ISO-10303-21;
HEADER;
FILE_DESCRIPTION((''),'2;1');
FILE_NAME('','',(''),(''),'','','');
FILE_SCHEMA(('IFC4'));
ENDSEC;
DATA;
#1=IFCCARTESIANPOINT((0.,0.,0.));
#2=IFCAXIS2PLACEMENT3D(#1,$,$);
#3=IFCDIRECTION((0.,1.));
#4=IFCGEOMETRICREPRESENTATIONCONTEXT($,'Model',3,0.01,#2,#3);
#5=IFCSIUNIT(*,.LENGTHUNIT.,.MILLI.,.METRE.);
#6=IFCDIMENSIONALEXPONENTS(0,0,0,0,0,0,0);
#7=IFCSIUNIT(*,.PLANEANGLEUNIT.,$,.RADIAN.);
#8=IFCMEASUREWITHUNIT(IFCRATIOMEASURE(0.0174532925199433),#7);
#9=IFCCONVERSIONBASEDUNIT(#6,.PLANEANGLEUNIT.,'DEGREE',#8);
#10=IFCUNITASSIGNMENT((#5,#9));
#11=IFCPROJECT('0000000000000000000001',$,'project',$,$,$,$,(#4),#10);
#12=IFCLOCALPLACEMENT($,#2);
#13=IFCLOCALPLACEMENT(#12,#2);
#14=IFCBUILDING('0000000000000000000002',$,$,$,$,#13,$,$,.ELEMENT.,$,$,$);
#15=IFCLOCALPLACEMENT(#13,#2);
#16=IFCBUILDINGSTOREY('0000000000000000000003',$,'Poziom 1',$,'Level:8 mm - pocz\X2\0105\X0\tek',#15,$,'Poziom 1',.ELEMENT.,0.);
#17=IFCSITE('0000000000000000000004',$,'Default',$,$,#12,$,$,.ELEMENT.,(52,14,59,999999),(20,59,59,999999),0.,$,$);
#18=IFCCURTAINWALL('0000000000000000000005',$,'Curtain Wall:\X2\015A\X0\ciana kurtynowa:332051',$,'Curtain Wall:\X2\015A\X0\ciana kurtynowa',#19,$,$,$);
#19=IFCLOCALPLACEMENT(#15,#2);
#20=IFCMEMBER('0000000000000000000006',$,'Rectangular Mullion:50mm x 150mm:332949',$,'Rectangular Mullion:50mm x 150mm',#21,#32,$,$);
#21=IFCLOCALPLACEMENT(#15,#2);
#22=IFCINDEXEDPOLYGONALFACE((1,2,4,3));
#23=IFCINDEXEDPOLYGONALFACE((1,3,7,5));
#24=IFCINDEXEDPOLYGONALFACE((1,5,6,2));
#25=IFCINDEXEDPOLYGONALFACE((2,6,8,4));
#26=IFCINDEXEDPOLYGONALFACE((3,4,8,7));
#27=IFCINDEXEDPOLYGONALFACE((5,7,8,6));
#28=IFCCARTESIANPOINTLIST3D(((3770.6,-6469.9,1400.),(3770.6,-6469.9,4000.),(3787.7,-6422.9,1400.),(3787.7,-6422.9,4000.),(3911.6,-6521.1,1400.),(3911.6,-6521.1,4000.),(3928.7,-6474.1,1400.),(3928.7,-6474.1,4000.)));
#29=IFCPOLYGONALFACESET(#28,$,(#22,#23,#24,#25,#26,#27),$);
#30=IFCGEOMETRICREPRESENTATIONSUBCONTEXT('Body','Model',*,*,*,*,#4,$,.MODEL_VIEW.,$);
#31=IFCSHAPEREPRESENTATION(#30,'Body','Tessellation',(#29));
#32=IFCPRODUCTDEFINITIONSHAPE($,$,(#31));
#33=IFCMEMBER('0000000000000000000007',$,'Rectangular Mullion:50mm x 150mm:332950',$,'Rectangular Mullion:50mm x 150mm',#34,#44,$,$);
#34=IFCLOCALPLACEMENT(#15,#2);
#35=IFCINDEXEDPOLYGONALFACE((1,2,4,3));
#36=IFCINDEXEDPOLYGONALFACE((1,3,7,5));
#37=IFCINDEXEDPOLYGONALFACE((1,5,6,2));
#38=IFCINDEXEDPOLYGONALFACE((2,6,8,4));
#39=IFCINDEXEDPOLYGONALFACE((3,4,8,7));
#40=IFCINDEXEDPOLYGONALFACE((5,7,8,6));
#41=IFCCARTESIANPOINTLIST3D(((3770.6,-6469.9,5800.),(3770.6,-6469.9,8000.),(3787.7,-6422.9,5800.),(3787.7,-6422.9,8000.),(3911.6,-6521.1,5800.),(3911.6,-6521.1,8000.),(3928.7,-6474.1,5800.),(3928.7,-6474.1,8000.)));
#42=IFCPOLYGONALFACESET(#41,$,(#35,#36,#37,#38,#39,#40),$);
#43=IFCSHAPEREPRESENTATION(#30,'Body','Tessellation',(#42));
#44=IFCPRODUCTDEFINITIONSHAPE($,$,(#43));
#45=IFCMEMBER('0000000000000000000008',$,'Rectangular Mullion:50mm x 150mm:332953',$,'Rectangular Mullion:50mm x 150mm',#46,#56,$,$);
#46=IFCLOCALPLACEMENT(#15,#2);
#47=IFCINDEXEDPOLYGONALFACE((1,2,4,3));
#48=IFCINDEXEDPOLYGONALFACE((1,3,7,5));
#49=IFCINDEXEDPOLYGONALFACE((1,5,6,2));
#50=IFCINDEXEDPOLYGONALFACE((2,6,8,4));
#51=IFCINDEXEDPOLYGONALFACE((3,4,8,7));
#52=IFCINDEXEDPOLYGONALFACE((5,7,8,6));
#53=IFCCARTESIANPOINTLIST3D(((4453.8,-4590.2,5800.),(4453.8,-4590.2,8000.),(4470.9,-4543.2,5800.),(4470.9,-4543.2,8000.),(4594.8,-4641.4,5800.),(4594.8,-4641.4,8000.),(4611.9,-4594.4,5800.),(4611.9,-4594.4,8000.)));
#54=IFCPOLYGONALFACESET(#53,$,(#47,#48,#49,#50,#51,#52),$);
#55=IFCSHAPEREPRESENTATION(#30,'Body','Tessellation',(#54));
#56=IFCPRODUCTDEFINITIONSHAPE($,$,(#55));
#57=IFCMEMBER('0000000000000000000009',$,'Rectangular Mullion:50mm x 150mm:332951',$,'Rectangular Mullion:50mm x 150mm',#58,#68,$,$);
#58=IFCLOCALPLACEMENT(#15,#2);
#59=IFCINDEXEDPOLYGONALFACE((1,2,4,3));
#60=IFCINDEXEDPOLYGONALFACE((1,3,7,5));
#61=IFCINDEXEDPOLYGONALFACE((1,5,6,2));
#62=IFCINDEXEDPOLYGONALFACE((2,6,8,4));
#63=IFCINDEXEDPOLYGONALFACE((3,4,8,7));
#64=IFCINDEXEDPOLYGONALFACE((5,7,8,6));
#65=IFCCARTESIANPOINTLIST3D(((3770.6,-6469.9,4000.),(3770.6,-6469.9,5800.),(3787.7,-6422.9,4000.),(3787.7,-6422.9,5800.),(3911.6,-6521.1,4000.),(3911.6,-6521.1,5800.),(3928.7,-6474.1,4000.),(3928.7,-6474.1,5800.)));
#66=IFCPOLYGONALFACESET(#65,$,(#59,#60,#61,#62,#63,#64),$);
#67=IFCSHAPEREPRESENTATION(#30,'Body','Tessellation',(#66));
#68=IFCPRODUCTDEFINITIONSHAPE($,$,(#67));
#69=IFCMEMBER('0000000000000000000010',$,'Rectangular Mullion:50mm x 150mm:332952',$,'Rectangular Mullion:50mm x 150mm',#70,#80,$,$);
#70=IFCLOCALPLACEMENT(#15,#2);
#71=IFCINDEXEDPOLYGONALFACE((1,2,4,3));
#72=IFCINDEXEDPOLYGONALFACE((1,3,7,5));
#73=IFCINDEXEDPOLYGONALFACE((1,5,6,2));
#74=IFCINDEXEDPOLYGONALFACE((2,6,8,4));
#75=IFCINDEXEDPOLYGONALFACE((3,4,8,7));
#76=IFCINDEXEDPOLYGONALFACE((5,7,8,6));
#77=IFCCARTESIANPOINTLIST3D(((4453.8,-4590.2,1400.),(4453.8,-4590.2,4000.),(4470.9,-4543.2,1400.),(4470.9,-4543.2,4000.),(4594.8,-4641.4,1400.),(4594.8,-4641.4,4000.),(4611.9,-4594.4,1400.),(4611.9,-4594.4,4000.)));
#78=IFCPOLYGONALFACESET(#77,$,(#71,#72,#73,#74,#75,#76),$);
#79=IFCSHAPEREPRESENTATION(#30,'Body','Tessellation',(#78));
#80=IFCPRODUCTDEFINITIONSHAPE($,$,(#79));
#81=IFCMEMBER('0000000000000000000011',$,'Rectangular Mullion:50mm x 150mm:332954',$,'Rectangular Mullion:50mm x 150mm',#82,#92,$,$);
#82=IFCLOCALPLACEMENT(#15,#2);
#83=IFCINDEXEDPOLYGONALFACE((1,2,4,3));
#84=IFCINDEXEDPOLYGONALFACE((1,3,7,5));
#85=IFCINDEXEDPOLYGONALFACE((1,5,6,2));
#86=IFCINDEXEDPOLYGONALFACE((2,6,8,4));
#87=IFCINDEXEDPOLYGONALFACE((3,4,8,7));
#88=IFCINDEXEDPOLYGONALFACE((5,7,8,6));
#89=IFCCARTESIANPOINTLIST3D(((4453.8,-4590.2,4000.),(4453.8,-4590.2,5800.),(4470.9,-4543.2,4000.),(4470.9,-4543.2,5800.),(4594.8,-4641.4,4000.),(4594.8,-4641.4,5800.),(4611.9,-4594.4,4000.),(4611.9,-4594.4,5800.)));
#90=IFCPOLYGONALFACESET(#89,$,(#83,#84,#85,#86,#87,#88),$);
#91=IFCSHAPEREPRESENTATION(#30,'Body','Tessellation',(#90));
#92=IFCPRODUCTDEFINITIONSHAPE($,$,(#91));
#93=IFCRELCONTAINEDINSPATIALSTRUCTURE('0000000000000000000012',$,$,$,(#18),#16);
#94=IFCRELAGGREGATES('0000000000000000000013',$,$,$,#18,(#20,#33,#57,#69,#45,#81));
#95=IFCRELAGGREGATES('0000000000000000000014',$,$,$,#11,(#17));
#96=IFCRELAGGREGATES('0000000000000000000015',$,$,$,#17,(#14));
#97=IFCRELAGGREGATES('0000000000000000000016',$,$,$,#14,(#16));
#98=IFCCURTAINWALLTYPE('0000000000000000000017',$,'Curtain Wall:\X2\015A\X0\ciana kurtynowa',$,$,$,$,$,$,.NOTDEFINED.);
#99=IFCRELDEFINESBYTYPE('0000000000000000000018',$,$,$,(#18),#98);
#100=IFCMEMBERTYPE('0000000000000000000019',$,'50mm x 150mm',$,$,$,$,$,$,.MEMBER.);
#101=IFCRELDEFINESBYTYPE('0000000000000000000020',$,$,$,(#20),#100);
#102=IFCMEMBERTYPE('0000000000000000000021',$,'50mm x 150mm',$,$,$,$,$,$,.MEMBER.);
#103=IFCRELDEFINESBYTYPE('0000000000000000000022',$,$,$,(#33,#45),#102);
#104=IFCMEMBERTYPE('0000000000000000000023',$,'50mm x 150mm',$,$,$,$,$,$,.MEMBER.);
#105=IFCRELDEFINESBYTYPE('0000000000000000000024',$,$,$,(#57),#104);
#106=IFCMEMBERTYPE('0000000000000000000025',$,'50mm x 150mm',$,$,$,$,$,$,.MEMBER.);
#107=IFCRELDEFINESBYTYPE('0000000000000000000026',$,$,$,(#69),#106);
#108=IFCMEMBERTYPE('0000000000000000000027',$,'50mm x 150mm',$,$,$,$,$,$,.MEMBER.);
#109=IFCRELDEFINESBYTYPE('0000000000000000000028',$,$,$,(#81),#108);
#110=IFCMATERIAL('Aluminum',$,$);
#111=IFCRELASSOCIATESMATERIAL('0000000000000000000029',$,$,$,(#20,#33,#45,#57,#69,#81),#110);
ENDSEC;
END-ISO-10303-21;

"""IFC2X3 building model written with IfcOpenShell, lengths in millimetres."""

from ifc_helpers import new_model, entity, si_unit, converted_unit, direction, frame, origin, origin_2d_with_axis, place, context, subcontext, project, spatial, rectangle, extrude, source, transform, mapped, material, type_object, type_shapes, element, aggregate, save


model = new_model("IFC2X3")

# Units and contexts
model_context = context("Model", 3, precision=0.01, world=origin(), true_north=direction((0.0, 1.0)))
body_context = subcontext(model_context, "Body", "Model", "MODEL_VIEW")
ifc_project = project(units=[si_unit("LENGTHUNIT", "METRE", prefix="MILLI"), converted_unit("PLANEANGLEUNIT", "DEGREE", entity("IfcRatioMeasure", 0.0174532925199433), si_unit("PLANEANGLEUNIT", "RADIAN"), dimensions=[0, 0, 0, 0, 0, 0, 0])], contexts=[model_context])

# Site, building, storey
site_placement = place(None, origin())
site = spatial("IfcSite", under=ifc_project, at=site_placement, Name="Default", CompositionType="ELEMENT", RefLatitude=(52, 14, 59, 999999), RefLongitude=(20, 59, 59, 999999), RefElevation=0.0)
building_placement = place(site_placement, origin())
building = spatial("IfcBuilding", under=site, at=building_placement, CompositionType="ELEMENT")
storey_placement = place(building_placement, origin())
storey = spatial("IfcBuildingStorey", under=building, at=storey_placement, Name="Poziom 1", ObjectType="Level:8 mm - początek", LongName="Poziom 1", CompositionType="ELEMENT", Elevation=0.0)

# Curtain wall, members
curtain_wall_type = type_object("IfcCurtainWallType", Name="Curtain Wall:Ściana kurtynowa", PredefinedType="NOTDEFINED")
curtain_wall_placement = place(storey_placement, origin())
curtain_wall = element("IfcCurtainWall", 1, at=curtain_wall_placement, inside=storey, type_object=curtain_wall_type, Name="Curtain Wall:Ściana kurtynowa:332051", ObjectType="Curtain Wall:Ściana kurtynowa")
ifc_material_1 = material(Name="Aluminum")
member_type_1 = type_object("IfcMemberType", Name="50mm x 150mm", PredefinedType="MEMBER")
shared_shape_1 = source(origin(), body_context, "Body", "SweptSolid", [
    extrude(rectangle(XDim=150.0, YDim=50.0, at=origin_2d_with_axis()), frame((0.0, 0.0, -2600.0), z_axis=(0.0, 0.0, 1.0), x_axis=(0.0, -1.0, 0.0)), (0.0, 0.0, 1.0), 2600.0),
])
type_shapes(member_type_1, [shared_shape_1])
member_1_placement = place(storey_placement, frame((3849.7, -6472.0, 1400.0), z_axis=(0.0, 0.0, -1.0), x_axis=(0.341586, 0.939851, 0.0)))
member_1 = element("IfcMember", 2, at=member_1_placement, type_object=member_type_1, material=ifc_material_1, Name="Rectangular Mullion:50mm x 150mm:332949", ObjectType="Rectangular Mullion:50mm x 150mm", context=body_context, shape_type="MappedRepresentation", body=[
    mapped(shared_shape_1, transform((0.0, 0.0, 0.0), scale=1.0)),
])
member_type_2 = type_object("IfcMemberType", Name="50mm x 150mm", PredefinedType="MEMBER")
shared_shape_2 = source(origin(), body_context, "Body", "SweptSolid", [
    extrude(rectangle(XDim=150.0, YDim=50.0, at=origin_2d_with_axis()), frame((0.0, 0.0, -2200.0), z_axis=(0.0, 0.0, 1.0), x_axis=(0.0, -1.0, 0.0)), (0.0, 0.0, 1.0), 2200.0),
])
type_shapes(member_type_2, [shared_shape_2])
member_2_placement = place(storey_placement, frame((3849.7, -6472.0, 5800.0), z_axis=(0.0, 0.0, -1.0), x_axis=(0.341586, 0.939851, 0.0)))
member_2 = element("IfcMember", 3, at=member_2_placement, type_object=member_type_2, material=ifc_material_1, Name="Rectangular Mullion:50mm x 150mm:332950", ObjectType="Rectangular Mullion:50mm x 150mm", context=body_context, shape_type="MappedRepresentation", body=[
    mapped(shared_shape_2, transform((0.0, 0.0, 0.0), scale=1.0)),
])
member_3_placement = place(storey_placement, frame((4532.8, -4592.3, 5800.0), z_axis=(0.0, 0.0, -1.0), x_axis=(0.341586, 0.939851, 0.0)))
member_3 = element("IfcMember", 4, at=member_3_placement, type_object=member_type_2, material=ifc_material_1, Name="Rectangular Mullion:50mm x 150mm:332953", ObjectType="Rectangular Mullion:50mm x 150mm", context=body_context, shape_type="MappedRepresentation", body=[
    mapped(shared_shape_2, transform((0.0, 0.0, 0.0), scale=1.0)),
])
member_type_3 = type_object("IfcMemberType", Name="50mm x 150mm", PredefinedType="MEMBER")
shared_shape_3 = source(origin(), body_context, "Body", "SweptSolid", [
    extrude(rectangle(XDim=150.0, YDim=50.0, at=origin_2d_with_axis()), frame((0.0, 0.0, -1800.0), z_axis=(0.0, 0.0, 1.0), x_axis=(0.0, -1.0, 0.0)), (0.0, 0.0, 1.0), 1800.0),
])
type_shapes(member_type_3, [shared_shape_3])
member_4_placement = place(storey_placement, frame((3849.7, -6472.0, 4000.0), z_axis=(0.0, 0.0, -1.0), x_axis=(0.341586, 0.939851, 0.0)))
member_4 = element("IfcMember", 5, at=member_4_placement, type_object=member_type_3, material=ifc_material_1, Name="Rectangular Mullion:50mm x 150mm:332951", ObjectType="Rectangular Mullion:50mm x 150mm", context=body_context, shape_type="MappedRepresentation", body=[
    mapped(shared_shape_3, transform((0.0, 0.0, 0.0), scale=1.0)),
])
member_type_4 = type_object("IfcMemberType", Name="50mm x 150mm", PredefinedType="MEMBER")
shared_shape_4 = source(origin(), body_context, "Body", "SweptSolid", [
    extrude(rectangle(XDim=150.0, YDim=50.0, at=origin_2d_with_axis()), frame((0.0, 0.0, -2600.0), z_axis=(0.0, 0.0, 1.0), x_axis=(0.0, -1.0, 0.0)), (0.0, 0.0, 1.0), 2600.0),
])
type_shapes(member_type_4, [shared_shape_4])
member_5_placement = place(storey_placement, frame((4532.8, -4592.3, 1400.0), z_axis=(0.0, 0.0, -1.0), x_axis=(0.341586, 0.939851, 0.0)))
member_5 = element("IfcMember", 6, at=member_5_placement, type_object=member_type_4, material=ifc_material_1, Name="Rectangular Mullion:50mm x 150mm:332952", ObjectType="Rectangular Mullion:50mm x 150mm", context=body_context, shape_type="MappedRepresentation", body=[
    mapped(shared_shape_4, transform((0.0, 0.0, 0.0), scale=1.0)),
])
member_type_5 = type_object("IfcMemberType", Name="50mm x 150mm", PredefinedType="MEMBER")
shared_shape_5 = source(origin(), body_context, "Body", "SweptSolid", [
    extrude(rectangle(XDim=150.0, YDim=50.0, at=origin_2d_with_axis()), frame((0.0, 0.0, -1800.0), z_axis=(0.0, 0.0, 1.0), x_axis=(0.0, -1.0, 0.0)), (0.0, 0.0, 1.0), 1800.0),
])
type_shapes(member_type_5, [shared_shape_5])
member_6_placement = place(storey_placement, frame((4532.8, -4592.3, 4000.0), z_axis=(0.0, 0.0, -1.0), x_axis=(0.341586, 0.939851, 0.0)))
member_6 = element("IfcMember", 7, at=member_6_placement, type_object=member_type_5, material=ifc_material_1, Name="Rectangular Mullion:50mm x 150mm:332954", ObjectType="Rectangular Mullion:50mm x 150mm", context=body_context, shape_type="MappedRepresentation", body=[
    mapped(shared_shape_5, transform((0.0, 0.0, 0.0), scale=1.0)),
])
aggregate(curtain_wall, [member_1, member_2, member_4, member_5, member_3, member_6])

save(model, "model.ifc")
